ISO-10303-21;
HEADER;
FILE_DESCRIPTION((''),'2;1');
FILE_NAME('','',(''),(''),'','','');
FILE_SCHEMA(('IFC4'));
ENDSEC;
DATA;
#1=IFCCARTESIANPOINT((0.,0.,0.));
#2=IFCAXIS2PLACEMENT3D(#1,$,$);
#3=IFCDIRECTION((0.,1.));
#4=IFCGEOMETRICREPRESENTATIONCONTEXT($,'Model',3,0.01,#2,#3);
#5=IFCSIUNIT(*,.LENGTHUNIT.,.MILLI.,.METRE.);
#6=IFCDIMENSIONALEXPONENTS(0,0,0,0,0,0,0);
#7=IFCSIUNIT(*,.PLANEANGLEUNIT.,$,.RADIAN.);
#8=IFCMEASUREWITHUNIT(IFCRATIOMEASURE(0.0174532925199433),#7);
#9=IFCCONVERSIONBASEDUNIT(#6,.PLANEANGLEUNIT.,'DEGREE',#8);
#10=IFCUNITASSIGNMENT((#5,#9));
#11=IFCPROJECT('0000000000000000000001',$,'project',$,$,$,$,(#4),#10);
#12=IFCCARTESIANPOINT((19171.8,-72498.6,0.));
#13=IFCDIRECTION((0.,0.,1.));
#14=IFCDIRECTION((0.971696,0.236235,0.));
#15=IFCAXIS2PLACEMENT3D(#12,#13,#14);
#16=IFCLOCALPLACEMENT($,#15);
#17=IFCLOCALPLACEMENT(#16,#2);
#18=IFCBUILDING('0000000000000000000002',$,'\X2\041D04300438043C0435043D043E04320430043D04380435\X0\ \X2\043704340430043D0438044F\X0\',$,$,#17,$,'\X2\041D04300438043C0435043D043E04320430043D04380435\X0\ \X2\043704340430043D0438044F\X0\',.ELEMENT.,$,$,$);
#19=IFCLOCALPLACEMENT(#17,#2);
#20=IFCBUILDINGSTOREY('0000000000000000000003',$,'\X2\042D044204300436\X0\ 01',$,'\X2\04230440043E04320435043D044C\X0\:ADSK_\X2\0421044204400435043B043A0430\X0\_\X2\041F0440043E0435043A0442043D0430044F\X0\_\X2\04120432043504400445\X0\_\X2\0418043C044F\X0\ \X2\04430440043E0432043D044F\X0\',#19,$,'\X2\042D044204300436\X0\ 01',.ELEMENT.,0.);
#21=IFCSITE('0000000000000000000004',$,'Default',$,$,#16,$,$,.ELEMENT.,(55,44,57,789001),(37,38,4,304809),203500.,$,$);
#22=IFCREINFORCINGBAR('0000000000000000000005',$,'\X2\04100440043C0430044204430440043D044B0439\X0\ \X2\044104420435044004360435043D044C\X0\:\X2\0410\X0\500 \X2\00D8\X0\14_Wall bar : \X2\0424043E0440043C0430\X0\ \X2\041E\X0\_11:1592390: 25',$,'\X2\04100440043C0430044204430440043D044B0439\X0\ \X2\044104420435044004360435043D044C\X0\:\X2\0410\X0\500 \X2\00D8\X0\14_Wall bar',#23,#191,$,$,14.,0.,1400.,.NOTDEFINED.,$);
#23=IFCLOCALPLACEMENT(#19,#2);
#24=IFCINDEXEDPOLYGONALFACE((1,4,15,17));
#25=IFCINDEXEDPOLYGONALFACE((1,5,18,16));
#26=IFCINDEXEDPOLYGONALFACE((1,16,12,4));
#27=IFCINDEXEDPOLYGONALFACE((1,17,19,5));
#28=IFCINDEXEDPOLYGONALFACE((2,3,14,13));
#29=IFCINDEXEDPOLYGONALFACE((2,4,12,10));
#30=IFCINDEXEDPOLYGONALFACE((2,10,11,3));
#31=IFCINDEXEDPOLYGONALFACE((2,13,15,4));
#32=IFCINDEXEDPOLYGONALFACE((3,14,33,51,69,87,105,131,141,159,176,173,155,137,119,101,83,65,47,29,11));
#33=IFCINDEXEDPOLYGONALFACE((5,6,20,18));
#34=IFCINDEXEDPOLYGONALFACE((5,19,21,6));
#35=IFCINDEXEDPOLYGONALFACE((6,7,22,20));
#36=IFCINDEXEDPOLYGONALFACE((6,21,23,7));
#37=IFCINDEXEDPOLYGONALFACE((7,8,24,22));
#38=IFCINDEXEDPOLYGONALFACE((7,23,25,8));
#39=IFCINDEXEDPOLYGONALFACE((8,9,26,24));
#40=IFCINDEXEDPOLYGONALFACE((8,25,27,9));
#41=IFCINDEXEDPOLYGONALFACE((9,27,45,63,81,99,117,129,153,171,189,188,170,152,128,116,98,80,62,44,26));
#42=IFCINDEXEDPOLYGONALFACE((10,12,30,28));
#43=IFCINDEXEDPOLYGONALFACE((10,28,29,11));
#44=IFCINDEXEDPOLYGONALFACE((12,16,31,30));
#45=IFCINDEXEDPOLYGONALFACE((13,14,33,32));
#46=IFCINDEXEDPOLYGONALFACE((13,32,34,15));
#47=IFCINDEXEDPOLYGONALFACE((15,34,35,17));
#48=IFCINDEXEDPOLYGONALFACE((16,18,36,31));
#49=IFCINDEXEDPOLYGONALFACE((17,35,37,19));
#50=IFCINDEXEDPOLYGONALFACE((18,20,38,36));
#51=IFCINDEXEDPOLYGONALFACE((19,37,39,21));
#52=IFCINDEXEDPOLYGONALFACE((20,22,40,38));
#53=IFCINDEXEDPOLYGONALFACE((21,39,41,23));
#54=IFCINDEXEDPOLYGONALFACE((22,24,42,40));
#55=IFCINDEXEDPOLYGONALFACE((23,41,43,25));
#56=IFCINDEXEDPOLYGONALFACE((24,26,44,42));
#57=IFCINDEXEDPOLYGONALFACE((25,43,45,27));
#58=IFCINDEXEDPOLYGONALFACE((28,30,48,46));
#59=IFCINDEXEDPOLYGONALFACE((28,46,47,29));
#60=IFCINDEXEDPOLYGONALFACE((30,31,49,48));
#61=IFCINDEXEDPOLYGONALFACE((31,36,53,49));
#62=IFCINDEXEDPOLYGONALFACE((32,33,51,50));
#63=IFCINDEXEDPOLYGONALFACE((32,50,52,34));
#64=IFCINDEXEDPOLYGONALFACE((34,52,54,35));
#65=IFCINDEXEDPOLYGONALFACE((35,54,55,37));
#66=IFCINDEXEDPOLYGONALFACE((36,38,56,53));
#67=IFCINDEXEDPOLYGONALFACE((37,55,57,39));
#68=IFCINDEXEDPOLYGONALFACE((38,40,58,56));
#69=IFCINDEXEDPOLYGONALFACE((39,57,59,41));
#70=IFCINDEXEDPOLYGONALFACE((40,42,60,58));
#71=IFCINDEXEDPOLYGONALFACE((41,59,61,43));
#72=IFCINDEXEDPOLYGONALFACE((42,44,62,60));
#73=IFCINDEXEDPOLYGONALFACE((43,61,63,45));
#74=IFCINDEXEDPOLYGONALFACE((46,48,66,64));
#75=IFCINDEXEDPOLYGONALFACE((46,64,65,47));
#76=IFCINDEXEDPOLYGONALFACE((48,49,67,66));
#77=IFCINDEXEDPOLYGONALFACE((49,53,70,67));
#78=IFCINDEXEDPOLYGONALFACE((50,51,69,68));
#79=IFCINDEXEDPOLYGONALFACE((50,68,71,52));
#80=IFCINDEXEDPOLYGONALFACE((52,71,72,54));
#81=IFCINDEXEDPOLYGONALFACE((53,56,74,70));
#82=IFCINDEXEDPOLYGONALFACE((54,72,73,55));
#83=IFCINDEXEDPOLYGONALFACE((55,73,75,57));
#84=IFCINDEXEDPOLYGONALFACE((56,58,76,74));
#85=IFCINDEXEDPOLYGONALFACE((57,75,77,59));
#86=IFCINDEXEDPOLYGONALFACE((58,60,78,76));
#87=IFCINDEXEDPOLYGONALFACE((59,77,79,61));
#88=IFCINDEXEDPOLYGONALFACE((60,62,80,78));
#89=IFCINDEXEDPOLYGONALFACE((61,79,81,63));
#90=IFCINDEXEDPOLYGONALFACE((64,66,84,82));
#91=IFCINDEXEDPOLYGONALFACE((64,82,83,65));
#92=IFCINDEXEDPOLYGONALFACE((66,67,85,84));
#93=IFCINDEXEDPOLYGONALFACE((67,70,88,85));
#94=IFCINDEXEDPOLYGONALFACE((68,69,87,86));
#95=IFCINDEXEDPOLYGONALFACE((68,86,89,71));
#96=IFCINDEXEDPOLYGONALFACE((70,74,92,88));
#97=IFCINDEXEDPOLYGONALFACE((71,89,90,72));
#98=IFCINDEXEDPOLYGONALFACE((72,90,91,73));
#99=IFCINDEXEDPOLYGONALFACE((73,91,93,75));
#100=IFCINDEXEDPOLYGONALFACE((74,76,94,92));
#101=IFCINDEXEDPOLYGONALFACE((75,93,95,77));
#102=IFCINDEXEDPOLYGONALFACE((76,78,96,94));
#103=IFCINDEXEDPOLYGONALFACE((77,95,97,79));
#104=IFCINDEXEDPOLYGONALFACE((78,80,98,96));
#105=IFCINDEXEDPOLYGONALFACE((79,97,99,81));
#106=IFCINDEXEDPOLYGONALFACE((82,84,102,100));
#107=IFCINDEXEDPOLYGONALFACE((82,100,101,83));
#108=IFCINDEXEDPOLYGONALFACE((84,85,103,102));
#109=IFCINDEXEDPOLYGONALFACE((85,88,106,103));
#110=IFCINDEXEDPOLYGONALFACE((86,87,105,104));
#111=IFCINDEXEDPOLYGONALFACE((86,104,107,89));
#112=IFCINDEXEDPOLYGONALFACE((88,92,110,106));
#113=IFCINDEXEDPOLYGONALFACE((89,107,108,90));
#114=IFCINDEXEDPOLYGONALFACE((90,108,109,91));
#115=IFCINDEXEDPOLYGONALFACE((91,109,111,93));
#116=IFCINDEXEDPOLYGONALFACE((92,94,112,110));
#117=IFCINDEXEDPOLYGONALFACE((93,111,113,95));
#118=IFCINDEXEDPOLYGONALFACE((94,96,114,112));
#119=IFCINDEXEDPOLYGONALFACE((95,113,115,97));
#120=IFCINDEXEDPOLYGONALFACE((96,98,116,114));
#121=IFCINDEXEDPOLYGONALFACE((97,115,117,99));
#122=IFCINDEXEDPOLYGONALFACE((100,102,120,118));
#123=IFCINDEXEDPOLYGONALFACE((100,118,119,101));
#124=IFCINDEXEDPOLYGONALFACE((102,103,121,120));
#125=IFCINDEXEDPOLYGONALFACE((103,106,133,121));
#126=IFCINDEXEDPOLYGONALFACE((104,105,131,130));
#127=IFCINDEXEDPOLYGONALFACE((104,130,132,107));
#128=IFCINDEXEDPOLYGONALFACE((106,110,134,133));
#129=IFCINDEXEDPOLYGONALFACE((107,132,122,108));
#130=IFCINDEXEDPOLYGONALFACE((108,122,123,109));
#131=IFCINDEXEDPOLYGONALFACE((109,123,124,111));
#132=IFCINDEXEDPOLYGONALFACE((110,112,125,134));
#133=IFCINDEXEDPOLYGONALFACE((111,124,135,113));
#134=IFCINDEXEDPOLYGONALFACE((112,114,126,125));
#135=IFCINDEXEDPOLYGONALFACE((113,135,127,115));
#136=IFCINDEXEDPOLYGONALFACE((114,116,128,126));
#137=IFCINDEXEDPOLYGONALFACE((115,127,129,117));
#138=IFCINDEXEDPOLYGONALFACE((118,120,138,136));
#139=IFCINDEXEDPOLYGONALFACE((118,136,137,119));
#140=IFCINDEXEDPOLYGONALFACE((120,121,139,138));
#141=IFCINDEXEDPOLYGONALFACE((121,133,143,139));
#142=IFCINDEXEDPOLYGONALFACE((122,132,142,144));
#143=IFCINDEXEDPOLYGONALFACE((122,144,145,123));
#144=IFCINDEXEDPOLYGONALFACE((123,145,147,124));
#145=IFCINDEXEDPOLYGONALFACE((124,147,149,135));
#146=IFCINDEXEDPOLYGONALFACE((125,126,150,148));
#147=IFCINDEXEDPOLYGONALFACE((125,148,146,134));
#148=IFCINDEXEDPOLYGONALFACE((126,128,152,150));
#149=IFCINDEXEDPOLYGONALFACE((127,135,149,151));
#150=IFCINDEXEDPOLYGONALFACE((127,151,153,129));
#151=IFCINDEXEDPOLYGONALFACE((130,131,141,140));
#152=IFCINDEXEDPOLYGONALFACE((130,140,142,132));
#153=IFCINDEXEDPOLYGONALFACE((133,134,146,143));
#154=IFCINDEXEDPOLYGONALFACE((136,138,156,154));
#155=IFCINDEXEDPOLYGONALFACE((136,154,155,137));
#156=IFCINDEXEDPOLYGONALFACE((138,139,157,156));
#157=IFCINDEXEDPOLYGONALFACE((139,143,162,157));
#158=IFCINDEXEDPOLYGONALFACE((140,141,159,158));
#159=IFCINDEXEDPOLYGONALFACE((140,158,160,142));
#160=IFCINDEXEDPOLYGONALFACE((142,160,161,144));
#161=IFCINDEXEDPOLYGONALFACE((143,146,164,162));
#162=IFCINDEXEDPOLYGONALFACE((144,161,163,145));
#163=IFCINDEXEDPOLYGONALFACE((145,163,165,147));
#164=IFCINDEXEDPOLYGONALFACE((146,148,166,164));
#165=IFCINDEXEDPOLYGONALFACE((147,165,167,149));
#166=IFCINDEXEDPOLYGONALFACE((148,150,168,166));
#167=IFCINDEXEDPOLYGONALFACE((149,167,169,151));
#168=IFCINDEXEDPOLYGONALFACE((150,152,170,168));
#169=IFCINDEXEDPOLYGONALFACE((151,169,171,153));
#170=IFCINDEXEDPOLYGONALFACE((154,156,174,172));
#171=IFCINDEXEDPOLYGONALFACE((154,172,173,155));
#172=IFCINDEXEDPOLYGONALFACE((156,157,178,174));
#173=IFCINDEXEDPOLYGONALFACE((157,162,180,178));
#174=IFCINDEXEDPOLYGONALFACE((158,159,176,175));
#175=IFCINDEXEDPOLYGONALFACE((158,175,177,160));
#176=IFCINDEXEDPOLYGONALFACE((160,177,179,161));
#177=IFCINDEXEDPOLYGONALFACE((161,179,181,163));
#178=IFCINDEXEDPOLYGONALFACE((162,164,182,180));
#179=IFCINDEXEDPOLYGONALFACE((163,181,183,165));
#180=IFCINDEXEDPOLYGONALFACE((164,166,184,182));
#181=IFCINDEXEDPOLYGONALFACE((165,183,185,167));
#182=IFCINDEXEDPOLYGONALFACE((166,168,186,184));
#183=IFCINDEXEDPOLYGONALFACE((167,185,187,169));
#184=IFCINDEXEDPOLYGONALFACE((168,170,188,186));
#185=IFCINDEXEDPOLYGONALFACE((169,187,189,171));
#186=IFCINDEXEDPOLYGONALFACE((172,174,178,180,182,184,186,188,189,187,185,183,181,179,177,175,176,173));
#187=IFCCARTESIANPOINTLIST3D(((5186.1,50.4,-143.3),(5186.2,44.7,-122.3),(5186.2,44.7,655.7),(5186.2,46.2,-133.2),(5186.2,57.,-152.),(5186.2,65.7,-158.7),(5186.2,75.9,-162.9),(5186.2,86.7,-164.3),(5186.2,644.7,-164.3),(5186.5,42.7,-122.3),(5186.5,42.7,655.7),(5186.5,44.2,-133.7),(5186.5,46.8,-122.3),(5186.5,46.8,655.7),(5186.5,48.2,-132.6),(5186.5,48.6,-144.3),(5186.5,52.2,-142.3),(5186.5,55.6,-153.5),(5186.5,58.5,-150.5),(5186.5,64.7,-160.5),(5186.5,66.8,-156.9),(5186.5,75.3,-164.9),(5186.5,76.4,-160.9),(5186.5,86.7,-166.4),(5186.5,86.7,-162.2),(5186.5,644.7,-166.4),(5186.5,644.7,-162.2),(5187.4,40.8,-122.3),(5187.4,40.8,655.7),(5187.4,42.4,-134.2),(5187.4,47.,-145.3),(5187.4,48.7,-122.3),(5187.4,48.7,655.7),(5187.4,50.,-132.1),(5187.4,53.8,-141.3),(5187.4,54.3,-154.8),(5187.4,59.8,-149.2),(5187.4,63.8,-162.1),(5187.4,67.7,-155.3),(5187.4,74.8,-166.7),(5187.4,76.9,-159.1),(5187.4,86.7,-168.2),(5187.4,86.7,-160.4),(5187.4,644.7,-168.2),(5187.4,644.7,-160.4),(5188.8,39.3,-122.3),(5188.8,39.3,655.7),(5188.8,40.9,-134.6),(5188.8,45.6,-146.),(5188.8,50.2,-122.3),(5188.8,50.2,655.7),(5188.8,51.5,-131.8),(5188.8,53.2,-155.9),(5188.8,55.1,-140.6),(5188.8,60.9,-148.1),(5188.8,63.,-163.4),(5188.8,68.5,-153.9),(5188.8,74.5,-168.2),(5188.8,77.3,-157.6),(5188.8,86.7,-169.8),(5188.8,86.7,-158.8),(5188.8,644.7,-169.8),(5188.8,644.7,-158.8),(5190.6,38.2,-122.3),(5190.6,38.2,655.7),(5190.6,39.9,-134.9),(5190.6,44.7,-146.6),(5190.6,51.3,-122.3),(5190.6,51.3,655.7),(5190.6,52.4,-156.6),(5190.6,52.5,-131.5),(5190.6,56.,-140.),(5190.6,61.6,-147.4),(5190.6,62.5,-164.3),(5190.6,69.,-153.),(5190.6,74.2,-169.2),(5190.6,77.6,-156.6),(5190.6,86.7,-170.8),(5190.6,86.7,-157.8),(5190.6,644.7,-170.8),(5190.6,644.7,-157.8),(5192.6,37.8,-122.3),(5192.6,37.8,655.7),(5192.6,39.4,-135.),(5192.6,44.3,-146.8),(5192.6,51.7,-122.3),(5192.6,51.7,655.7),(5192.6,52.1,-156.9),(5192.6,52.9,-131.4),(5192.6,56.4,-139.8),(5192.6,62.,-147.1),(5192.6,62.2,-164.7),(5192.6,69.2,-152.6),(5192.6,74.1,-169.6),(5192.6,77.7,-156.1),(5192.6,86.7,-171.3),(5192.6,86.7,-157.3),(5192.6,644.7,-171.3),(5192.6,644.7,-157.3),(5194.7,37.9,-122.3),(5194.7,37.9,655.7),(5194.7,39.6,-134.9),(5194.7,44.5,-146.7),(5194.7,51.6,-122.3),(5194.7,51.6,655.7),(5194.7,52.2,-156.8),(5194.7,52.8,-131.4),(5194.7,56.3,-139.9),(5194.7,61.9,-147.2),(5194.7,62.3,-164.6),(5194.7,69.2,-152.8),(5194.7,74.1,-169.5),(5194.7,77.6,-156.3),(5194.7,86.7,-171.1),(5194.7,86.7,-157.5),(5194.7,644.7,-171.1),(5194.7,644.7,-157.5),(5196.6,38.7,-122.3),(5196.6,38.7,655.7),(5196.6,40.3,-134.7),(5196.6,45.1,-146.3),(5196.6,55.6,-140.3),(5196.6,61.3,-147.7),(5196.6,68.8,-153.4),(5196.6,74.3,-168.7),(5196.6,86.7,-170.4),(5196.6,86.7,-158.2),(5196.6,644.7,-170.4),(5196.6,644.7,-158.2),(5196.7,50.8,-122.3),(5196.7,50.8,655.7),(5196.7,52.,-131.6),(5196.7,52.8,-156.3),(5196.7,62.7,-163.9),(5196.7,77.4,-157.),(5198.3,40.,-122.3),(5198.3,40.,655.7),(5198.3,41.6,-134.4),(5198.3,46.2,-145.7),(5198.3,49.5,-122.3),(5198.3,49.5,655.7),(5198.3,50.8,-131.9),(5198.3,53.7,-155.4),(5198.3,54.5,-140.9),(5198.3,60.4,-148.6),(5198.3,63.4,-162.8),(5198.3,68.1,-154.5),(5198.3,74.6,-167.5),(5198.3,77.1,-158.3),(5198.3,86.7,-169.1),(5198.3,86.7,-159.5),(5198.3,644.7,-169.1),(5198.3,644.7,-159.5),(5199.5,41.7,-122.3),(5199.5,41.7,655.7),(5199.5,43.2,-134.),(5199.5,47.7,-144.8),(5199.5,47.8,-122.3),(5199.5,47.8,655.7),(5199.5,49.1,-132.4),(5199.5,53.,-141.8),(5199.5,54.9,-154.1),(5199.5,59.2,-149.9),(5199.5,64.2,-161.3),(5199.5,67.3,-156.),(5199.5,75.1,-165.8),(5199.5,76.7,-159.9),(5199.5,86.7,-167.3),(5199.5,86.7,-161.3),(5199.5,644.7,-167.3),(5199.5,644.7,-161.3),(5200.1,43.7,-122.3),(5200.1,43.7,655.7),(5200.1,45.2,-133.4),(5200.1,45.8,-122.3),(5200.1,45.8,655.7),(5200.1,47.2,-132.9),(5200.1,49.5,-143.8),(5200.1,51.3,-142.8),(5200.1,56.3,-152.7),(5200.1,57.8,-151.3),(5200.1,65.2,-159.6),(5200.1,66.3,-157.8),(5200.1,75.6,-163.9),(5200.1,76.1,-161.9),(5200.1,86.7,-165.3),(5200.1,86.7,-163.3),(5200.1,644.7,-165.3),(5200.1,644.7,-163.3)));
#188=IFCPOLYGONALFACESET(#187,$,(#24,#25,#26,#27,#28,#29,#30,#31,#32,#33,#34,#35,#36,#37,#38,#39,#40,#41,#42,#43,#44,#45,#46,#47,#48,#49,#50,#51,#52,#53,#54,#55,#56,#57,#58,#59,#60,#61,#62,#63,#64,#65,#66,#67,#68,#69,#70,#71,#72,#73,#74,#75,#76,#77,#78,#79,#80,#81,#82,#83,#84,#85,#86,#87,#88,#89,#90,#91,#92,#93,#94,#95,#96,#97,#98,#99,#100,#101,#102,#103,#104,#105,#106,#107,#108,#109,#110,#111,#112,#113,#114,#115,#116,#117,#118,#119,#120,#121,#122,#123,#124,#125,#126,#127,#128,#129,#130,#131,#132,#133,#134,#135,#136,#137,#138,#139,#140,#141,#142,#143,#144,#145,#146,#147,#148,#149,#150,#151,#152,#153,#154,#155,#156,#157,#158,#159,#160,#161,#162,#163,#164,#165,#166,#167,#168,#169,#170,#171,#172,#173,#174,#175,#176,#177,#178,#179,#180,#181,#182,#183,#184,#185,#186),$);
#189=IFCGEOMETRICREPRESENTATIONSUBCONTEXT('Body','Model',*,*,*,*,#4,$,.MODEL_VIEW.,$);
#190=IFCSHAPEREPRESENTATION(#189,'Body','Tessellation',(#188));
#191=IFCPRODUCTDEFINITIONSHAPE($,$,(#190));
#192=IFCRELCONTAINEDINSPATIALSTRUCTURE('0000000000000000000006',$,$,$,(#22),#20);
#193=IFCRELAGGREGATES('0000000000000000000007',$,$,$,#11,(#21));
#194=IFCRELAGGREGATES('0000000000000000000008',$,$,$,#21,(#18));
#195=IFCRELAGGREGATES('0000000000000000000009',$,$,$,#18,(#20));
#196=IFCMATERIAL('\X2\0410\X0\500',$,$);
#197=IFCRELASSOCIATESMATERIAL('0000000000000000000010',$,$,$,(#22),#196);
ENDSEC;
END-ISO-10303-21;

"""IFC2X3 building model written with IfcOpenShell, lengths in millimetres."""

from ifc_helpers import new_model, entity, si_unit, converted_unit, direction, frame, origin, place, context, subcontext, project, spatial, material, element, save


model = new_model("IFC2X3")

# Units and contexts
model_context = context("Model", 3, precision=0.01, world=origin(), true_north=direction((0.0, 1.0)))
body_context = subcontext(model_context, "Body", "Model", "MODEL_VIEW")
ifc_project = project(units=[si_unit("LENGTHUNIT", "METRE", prefix="MILLI"), converted_unit("PLANEANGLEUNIT", "DEGREE", entity("IfcRatioMeasure", 0.0174532925199433), si_unit("PLANEANGLEUNIT", "RADIAN"), dimensions=[0, 0, 0, 0, 0, 0, 0])], contexts=[model_context])

# Site, building, storey
site_placement = place(None, frame((19171.8, -72498.6, 0.0), z_axis=(0.0, 0.0, 1.0), x_axis=(0.971696, 0.236235, 0.0)))
site = spatial("IfcSite", under=ifc_project, at=site_placement, Name="Default", CompositionType="ELEMENT", RefLatitude=(55, 44, 57, 789001), RefLongitude=(37, 38, 4, 304809), RefElevation=203500.0)
building_placement = place(site_placement, origin())
building = spatial("IfcBuilding", under=site, at=building_placement, Name="Наименование здания", LongName="Наименование здания", CompositionType="ELEMENT")
storey_placement = place(building_placement, origin())
storey = spatial("IfcBuildingStorey", under=building, at=storey_placement, Name="Этаж 01", ObjectType="Уровень:ADSK_Стрелка_Проектная_Вверх_Имя уровня", LongName="Этаж 01", CompositionType="ELEMENT", Elevation=0.0)

# Reinforcing bar
ifc_material = material(Name="А500")
placement = place(storey_placement, origin())
element("IfcReinforcingBar", 1, at=placement, inside=storey, material=ifc_material, Name="Арматурный стержень:А500 Ø14_Wall bar : Форма О_11:1592390: 25", ObjectType="Арматурный стержень:А500 Ø14_Wall bar", BarLength=1400.0, BarRole="NOTDEFINED", CrossSectionArea=0.0, NominalDiameter=14.0, context=body_context, shape_type="AdvancedSweptSolid", body=[
    entity("IfcSweptDiskSolid", entity("IfcCompositeCurve", [entity("IfcCompositeCurveSegment", "CONTINUOUS", True, entity("IfcPolyline", [entity("IfcCartesianPoint", [5193.1, 44.7, 655.7]), entity("IfcCartesianPoint", [5193.1, 44.7, -122.3])])), entity("IfcCompositeCurveSegment", "CONTINUOUS", True, entity("IfcTrimmedCurve", entity("IfcCircle", entity("IfcAxis2Placement3D", entity("IfcCartesianPoint", [5193.1, 86.7, -122.3]), entity("IfcDirection", [1.0, 0.0, 0.0]), entity("IfcDirection", [0.0, 0.0, -1.0])), 42.0), [entity("IfcParameterValue", 270.0)], [entity("IfcParameterValue", 360.0)], True, "PARAMETER")), entity("IfcCompositeCurveSegment", "CONTINUOUS", True, entity("IfcPolyline", [entity("IfcCartesianPoint", [5193.1, 86.7, -164.3]), entity("IfcCartesianPoint", [5193.1, 644.7, -164.3])]))], False), 7.0, None, 0.0, 92.0),
])

save(model, "model.ifc")
